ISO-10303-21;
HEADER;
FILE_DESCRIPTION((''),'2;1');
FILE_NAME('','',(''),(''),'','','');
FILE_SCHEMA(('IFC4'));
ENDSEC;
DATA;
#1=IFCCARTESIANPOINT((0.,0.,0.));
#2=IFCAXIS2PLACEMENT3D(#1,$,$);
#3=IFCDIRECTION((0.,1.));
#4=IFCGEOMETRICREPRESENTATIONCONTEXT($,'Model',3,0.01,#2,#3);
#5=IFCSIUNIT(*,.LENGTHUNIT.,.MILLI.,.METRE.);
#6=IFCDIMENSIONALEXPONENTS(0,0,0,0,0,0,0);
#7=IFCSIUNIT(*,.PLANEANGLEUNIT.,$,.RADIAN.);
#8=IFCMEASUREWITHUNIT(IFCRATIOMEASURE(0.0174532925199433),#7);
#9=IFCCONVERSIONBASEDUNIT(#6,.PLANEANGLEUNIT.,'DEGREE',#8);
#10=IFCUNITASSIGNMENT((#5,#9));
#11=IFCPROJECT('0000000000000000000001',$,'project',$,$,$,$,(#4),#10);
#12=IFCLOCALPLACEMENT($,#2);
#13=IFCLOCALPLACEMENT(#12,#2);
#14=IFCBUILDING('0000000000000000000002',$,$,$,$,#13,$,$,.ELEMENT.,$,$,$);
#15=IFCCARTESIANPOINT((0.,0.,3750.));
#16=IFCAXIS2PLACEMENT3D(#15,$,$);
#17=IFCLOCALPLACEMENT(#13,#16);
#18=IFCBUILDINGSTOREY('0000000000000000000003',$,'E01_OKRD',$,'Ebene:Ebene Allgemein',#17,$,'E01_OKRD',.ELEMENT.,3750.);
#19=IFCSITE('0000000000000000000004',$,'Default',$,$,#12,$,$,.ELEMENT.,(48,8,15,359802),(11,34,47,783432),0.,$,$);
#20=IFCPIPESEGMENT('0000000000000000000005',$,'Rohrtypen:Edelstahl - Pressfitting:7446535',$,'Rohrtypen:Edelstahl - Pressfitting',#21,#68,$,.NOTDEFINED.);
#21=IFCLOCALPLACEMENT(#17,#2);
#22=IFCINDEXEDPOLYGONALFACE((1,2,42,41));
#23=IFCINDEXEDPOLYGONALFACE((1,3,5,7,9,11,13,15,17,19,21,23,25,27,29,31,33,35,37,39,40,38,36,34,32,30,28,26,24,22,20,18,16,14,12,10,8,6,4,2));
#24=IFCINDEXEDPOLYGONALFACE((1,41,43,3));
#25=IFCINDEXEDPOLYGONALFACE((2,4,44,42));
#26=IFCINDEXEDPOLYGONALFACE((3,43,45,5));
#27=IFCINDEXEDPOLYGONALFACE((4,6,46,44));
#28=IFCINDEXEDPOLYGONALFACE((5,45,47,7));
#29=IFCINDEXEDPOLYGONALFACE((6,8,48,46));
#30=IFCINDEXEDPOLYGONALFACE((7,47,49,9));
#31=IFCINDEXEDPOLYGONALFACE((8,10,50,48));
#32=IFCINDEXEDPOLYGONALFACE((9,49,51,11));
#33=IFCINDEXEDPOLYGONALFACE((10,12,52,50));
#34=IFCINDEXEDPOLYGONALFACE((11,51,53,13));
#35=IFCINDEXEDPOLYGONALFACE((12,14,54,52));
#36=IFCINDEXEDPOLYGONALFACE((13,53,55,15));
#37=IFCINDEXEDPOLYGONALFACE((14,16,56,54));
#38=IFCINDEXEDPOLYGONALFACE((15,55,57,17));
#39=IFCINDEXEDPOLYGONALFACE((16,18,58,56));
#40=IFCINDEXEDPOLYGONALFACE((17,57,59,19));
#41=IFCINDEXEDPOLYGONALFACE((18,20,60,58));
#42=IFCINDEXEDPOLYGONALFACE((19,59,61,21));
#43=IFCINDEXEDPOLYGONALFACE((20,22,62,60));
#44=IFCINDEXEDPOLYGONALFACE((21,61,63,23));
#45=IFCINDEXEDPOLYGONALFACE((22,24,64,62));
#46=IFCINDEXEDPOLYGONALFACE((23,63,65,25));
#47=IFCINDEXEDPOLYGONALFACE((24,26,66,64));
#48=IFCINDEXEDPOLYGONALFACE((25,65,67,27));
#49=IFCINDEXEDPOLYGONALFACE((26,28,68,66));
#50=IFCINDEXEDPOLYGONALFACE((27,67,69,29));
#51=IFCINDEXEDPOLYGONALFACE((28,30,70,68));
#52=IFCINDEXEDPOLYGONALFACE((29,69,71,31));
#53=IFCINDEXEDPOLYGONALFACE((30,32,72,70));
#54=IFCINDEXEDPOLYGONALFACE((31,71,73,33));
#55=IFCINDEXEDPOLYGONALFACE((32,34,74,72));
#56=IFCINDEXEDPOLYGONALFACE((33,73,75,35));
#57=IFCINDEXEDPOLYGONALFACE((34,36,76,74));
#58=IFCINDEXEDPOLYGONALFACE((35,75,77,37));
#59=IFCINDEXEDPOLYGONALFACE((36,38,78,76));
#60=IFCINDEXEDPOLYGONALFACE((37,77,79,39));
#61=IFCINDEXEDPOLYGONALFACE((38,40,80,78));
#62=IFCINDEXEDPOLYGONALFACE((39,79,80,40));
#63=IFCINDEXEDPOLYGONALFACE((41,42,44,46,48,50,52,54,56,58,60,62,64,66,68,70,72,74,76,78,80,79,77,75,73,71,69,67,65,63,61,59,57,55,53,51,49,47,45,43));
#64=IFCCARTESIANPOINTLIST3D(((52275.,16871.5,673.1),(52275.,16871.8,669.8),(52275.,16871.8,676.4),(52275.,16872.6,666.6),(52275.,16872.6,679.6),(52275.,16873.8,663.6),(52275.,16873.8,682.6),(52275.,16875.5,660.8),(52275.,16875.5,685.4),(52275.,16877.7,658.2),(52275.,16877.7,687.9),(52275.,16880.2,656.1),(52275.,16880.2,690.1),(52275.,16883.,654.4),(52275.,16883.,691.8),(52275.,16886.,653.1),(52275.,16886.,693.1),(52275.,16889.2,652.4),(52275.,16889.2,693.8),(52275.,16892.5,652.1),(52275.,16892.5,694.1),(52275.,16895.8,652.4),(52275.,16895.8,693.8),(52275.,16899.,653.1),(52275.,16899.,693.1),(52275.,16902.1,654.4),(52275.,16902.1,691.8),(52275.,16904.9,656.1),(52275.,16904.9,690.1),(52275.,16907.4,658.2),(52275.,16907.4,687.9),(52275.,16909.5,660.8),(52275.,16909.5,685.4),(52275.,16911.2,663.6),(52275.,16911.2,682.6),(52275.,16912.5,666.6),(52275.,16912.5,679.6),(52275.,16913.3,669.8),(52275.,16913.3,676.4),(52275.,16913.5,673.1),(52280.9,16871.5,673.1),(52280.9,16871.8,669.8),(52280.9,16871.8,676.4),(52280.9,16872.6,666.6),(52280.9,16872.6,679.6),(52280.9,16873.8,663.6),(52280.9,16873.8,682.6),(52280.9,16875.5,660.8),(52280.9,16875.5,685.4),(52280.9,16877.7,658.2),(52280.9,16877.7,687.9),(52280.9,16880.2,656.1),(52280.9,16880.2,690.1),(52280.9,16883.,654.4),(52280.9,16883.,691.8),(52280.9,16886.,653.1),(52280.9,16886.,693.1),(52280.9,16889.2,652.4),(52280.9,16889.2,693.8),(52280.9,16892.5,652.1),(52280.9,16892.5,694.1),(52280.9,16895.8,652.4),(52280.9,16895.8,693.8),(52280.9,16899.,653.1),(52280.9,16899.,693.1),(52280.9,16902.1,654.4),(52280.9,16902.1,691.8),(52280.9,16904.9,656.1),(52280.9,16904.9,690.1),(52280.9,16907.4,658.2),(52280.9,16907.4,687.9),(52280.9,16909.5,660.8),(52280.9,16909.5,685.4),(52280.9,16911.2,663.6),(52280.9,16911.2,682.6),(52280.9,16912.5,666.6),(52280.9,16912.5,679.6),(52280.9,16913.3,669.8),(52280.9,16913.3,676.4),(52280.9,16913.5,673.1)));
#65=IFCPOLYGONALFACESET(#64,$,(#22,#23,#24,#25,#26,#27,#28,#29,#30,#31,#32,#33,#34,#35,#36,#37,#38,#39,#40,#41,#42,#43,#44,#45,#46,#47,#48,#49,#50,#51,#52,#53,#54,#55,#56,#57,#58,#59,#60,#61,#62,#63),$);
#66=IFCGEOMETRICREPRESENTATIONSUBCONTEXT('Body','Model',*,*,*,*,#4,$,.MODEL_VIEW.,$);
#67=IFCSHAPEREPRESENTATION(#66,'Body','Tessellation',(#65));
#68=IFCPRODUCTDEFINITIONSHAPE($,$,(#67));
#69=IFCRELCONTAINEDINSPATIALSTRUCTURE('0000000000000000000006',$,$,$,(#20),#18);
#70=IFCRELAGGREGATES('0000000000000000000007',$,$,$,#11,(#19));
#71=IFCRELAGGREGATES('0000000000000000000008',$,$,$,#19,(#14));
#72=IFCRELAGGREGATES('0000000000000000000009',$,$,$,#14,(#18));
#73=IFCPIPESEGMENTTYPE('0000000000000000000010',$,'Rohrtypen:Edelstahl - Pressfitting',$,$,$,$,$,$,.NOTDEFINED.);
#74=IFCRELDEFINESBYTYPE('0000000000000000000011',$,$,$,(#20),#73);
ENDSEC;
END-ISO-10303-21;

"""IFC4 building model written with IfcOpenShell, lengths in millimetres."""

from ifc_helpers import new_model, entity, si_unit, converted_unit, direction, frame, origin, place, context, subcontext, project, spatial, indexed_curve, outline, extrude, type_object, element, save


model = new_model("IFC4")

# Units and contexts
model_context = context("Model", 3, precision=0.01, world=origin(), true_north=direction((0.0, 1.0)))
body_context = subcontext(model_context, "Body", "Model", "MODEL_VIEW")
ifc_project = project(units=[si_unit("LENGTHUNIT", "METRE", prefix="MILLI"), converted_unit("PLANEANGLEUNIT", "DEGREE", entity("IfcRatioMeasure", 0.0174532925199433), si_unit("PLANEANGLEUNIT", "RADIAN"), dimensions=[0, 0, 0, 0, 0, 0, 0])], contexts=[model_context])

# Site, building, storey
site_placement = place(None, origin())
site = spatial("IfcSite", under=ifc_project, at=site_placement, Name="Default", CompositionType="ELEMENT", RefLatitude=(48, 8, 15, 359802), RefLongitude=(11, 34, 47, 783432), RefElevation=0.0)
building_placement = place(site_placement, origin())
building = spatial("IfcBuilding", under=site, at=building_placement, CompositionType="ELEMENT")
storey_placement = place(building_placement, frame((0.0, 0.0, 3750.0)))
storey = spatial("IfcBuildingStorey", under=building, at=storey_placement, Name="E01_OKRD", ObjectType="Ebene:Ebene Allgemein", LongName="E01_OKRD", CompositionType="ELEMENT", Elevation=3750.0)

# Pipe segment
pipe_segment_type_1 = type_object("IfcPipeSegmentType", Name="Rohrtypen:Edelstahl - Pressfitting", PredefinedType="NOTDEFINED")
pipe_segment_1_placement = place(storey_placement, origin())
element("IfcPipeSegment", 1, at=pipe_segment_1_placement, inside=storey, type_object=pipe_segment_type_1, Name="Rohrtypen:Edelstahl - Pressfitting:7446535", ObjectType="Rohrtypen:Edelstahl - Pressfitting", PredefinedType="NOTDEFINED", context=body_context, shape_type="SweptSolid", body=[
    extrude(outline(indexed_curve([(21.0, 0.0), (20.7, 3.3), (20.0, 6.5), (18.7, 9.5), (17.0, 12.3), (14.8, 14.8), (12.3, 17.0), (9.5, 18.7), (6.5, 20.0), (3.3, 20.7), (0.0, 21.0), (-3.3, 20.7), (-6.5, 20.0), (-9.5, 18.7), (-12.3, 17.0), (-14.8, 14.8), (-17.0, 12.3), (-18.7, 9.5), (-20.0, 6.5), (-20.7, 3.3), (-21.0, 0.0), (-20.7, -3.3), (-20.0, -6.5), (-18.7, -9.5), (-17.0, -12.3), (-14.8, -14.8), (-12.3, -17.0), (-9.5, -18.7), (-6.5, -20.0), (-3.3, -20.7), (0.0, -21.0), (3.3, -20.7), (6.5, -20.0), (9.5, -18.7), (12.3, -17.0), (14.8, -14.8), (17.0, -12.3), (18.7, -9.5), (20.0, -6.5), (20.7, -3.3), (21.0, 0.0)], self_intersect=False)), frame((52275.0, 16892.5, 673.1), z_axis=(1.0, 0.0, 0.0), x_axis=(0.0, -1.0, 0.0)), (0.0, 0.0, 1.0), 5.9),
])

save(model, "model.ifc")
